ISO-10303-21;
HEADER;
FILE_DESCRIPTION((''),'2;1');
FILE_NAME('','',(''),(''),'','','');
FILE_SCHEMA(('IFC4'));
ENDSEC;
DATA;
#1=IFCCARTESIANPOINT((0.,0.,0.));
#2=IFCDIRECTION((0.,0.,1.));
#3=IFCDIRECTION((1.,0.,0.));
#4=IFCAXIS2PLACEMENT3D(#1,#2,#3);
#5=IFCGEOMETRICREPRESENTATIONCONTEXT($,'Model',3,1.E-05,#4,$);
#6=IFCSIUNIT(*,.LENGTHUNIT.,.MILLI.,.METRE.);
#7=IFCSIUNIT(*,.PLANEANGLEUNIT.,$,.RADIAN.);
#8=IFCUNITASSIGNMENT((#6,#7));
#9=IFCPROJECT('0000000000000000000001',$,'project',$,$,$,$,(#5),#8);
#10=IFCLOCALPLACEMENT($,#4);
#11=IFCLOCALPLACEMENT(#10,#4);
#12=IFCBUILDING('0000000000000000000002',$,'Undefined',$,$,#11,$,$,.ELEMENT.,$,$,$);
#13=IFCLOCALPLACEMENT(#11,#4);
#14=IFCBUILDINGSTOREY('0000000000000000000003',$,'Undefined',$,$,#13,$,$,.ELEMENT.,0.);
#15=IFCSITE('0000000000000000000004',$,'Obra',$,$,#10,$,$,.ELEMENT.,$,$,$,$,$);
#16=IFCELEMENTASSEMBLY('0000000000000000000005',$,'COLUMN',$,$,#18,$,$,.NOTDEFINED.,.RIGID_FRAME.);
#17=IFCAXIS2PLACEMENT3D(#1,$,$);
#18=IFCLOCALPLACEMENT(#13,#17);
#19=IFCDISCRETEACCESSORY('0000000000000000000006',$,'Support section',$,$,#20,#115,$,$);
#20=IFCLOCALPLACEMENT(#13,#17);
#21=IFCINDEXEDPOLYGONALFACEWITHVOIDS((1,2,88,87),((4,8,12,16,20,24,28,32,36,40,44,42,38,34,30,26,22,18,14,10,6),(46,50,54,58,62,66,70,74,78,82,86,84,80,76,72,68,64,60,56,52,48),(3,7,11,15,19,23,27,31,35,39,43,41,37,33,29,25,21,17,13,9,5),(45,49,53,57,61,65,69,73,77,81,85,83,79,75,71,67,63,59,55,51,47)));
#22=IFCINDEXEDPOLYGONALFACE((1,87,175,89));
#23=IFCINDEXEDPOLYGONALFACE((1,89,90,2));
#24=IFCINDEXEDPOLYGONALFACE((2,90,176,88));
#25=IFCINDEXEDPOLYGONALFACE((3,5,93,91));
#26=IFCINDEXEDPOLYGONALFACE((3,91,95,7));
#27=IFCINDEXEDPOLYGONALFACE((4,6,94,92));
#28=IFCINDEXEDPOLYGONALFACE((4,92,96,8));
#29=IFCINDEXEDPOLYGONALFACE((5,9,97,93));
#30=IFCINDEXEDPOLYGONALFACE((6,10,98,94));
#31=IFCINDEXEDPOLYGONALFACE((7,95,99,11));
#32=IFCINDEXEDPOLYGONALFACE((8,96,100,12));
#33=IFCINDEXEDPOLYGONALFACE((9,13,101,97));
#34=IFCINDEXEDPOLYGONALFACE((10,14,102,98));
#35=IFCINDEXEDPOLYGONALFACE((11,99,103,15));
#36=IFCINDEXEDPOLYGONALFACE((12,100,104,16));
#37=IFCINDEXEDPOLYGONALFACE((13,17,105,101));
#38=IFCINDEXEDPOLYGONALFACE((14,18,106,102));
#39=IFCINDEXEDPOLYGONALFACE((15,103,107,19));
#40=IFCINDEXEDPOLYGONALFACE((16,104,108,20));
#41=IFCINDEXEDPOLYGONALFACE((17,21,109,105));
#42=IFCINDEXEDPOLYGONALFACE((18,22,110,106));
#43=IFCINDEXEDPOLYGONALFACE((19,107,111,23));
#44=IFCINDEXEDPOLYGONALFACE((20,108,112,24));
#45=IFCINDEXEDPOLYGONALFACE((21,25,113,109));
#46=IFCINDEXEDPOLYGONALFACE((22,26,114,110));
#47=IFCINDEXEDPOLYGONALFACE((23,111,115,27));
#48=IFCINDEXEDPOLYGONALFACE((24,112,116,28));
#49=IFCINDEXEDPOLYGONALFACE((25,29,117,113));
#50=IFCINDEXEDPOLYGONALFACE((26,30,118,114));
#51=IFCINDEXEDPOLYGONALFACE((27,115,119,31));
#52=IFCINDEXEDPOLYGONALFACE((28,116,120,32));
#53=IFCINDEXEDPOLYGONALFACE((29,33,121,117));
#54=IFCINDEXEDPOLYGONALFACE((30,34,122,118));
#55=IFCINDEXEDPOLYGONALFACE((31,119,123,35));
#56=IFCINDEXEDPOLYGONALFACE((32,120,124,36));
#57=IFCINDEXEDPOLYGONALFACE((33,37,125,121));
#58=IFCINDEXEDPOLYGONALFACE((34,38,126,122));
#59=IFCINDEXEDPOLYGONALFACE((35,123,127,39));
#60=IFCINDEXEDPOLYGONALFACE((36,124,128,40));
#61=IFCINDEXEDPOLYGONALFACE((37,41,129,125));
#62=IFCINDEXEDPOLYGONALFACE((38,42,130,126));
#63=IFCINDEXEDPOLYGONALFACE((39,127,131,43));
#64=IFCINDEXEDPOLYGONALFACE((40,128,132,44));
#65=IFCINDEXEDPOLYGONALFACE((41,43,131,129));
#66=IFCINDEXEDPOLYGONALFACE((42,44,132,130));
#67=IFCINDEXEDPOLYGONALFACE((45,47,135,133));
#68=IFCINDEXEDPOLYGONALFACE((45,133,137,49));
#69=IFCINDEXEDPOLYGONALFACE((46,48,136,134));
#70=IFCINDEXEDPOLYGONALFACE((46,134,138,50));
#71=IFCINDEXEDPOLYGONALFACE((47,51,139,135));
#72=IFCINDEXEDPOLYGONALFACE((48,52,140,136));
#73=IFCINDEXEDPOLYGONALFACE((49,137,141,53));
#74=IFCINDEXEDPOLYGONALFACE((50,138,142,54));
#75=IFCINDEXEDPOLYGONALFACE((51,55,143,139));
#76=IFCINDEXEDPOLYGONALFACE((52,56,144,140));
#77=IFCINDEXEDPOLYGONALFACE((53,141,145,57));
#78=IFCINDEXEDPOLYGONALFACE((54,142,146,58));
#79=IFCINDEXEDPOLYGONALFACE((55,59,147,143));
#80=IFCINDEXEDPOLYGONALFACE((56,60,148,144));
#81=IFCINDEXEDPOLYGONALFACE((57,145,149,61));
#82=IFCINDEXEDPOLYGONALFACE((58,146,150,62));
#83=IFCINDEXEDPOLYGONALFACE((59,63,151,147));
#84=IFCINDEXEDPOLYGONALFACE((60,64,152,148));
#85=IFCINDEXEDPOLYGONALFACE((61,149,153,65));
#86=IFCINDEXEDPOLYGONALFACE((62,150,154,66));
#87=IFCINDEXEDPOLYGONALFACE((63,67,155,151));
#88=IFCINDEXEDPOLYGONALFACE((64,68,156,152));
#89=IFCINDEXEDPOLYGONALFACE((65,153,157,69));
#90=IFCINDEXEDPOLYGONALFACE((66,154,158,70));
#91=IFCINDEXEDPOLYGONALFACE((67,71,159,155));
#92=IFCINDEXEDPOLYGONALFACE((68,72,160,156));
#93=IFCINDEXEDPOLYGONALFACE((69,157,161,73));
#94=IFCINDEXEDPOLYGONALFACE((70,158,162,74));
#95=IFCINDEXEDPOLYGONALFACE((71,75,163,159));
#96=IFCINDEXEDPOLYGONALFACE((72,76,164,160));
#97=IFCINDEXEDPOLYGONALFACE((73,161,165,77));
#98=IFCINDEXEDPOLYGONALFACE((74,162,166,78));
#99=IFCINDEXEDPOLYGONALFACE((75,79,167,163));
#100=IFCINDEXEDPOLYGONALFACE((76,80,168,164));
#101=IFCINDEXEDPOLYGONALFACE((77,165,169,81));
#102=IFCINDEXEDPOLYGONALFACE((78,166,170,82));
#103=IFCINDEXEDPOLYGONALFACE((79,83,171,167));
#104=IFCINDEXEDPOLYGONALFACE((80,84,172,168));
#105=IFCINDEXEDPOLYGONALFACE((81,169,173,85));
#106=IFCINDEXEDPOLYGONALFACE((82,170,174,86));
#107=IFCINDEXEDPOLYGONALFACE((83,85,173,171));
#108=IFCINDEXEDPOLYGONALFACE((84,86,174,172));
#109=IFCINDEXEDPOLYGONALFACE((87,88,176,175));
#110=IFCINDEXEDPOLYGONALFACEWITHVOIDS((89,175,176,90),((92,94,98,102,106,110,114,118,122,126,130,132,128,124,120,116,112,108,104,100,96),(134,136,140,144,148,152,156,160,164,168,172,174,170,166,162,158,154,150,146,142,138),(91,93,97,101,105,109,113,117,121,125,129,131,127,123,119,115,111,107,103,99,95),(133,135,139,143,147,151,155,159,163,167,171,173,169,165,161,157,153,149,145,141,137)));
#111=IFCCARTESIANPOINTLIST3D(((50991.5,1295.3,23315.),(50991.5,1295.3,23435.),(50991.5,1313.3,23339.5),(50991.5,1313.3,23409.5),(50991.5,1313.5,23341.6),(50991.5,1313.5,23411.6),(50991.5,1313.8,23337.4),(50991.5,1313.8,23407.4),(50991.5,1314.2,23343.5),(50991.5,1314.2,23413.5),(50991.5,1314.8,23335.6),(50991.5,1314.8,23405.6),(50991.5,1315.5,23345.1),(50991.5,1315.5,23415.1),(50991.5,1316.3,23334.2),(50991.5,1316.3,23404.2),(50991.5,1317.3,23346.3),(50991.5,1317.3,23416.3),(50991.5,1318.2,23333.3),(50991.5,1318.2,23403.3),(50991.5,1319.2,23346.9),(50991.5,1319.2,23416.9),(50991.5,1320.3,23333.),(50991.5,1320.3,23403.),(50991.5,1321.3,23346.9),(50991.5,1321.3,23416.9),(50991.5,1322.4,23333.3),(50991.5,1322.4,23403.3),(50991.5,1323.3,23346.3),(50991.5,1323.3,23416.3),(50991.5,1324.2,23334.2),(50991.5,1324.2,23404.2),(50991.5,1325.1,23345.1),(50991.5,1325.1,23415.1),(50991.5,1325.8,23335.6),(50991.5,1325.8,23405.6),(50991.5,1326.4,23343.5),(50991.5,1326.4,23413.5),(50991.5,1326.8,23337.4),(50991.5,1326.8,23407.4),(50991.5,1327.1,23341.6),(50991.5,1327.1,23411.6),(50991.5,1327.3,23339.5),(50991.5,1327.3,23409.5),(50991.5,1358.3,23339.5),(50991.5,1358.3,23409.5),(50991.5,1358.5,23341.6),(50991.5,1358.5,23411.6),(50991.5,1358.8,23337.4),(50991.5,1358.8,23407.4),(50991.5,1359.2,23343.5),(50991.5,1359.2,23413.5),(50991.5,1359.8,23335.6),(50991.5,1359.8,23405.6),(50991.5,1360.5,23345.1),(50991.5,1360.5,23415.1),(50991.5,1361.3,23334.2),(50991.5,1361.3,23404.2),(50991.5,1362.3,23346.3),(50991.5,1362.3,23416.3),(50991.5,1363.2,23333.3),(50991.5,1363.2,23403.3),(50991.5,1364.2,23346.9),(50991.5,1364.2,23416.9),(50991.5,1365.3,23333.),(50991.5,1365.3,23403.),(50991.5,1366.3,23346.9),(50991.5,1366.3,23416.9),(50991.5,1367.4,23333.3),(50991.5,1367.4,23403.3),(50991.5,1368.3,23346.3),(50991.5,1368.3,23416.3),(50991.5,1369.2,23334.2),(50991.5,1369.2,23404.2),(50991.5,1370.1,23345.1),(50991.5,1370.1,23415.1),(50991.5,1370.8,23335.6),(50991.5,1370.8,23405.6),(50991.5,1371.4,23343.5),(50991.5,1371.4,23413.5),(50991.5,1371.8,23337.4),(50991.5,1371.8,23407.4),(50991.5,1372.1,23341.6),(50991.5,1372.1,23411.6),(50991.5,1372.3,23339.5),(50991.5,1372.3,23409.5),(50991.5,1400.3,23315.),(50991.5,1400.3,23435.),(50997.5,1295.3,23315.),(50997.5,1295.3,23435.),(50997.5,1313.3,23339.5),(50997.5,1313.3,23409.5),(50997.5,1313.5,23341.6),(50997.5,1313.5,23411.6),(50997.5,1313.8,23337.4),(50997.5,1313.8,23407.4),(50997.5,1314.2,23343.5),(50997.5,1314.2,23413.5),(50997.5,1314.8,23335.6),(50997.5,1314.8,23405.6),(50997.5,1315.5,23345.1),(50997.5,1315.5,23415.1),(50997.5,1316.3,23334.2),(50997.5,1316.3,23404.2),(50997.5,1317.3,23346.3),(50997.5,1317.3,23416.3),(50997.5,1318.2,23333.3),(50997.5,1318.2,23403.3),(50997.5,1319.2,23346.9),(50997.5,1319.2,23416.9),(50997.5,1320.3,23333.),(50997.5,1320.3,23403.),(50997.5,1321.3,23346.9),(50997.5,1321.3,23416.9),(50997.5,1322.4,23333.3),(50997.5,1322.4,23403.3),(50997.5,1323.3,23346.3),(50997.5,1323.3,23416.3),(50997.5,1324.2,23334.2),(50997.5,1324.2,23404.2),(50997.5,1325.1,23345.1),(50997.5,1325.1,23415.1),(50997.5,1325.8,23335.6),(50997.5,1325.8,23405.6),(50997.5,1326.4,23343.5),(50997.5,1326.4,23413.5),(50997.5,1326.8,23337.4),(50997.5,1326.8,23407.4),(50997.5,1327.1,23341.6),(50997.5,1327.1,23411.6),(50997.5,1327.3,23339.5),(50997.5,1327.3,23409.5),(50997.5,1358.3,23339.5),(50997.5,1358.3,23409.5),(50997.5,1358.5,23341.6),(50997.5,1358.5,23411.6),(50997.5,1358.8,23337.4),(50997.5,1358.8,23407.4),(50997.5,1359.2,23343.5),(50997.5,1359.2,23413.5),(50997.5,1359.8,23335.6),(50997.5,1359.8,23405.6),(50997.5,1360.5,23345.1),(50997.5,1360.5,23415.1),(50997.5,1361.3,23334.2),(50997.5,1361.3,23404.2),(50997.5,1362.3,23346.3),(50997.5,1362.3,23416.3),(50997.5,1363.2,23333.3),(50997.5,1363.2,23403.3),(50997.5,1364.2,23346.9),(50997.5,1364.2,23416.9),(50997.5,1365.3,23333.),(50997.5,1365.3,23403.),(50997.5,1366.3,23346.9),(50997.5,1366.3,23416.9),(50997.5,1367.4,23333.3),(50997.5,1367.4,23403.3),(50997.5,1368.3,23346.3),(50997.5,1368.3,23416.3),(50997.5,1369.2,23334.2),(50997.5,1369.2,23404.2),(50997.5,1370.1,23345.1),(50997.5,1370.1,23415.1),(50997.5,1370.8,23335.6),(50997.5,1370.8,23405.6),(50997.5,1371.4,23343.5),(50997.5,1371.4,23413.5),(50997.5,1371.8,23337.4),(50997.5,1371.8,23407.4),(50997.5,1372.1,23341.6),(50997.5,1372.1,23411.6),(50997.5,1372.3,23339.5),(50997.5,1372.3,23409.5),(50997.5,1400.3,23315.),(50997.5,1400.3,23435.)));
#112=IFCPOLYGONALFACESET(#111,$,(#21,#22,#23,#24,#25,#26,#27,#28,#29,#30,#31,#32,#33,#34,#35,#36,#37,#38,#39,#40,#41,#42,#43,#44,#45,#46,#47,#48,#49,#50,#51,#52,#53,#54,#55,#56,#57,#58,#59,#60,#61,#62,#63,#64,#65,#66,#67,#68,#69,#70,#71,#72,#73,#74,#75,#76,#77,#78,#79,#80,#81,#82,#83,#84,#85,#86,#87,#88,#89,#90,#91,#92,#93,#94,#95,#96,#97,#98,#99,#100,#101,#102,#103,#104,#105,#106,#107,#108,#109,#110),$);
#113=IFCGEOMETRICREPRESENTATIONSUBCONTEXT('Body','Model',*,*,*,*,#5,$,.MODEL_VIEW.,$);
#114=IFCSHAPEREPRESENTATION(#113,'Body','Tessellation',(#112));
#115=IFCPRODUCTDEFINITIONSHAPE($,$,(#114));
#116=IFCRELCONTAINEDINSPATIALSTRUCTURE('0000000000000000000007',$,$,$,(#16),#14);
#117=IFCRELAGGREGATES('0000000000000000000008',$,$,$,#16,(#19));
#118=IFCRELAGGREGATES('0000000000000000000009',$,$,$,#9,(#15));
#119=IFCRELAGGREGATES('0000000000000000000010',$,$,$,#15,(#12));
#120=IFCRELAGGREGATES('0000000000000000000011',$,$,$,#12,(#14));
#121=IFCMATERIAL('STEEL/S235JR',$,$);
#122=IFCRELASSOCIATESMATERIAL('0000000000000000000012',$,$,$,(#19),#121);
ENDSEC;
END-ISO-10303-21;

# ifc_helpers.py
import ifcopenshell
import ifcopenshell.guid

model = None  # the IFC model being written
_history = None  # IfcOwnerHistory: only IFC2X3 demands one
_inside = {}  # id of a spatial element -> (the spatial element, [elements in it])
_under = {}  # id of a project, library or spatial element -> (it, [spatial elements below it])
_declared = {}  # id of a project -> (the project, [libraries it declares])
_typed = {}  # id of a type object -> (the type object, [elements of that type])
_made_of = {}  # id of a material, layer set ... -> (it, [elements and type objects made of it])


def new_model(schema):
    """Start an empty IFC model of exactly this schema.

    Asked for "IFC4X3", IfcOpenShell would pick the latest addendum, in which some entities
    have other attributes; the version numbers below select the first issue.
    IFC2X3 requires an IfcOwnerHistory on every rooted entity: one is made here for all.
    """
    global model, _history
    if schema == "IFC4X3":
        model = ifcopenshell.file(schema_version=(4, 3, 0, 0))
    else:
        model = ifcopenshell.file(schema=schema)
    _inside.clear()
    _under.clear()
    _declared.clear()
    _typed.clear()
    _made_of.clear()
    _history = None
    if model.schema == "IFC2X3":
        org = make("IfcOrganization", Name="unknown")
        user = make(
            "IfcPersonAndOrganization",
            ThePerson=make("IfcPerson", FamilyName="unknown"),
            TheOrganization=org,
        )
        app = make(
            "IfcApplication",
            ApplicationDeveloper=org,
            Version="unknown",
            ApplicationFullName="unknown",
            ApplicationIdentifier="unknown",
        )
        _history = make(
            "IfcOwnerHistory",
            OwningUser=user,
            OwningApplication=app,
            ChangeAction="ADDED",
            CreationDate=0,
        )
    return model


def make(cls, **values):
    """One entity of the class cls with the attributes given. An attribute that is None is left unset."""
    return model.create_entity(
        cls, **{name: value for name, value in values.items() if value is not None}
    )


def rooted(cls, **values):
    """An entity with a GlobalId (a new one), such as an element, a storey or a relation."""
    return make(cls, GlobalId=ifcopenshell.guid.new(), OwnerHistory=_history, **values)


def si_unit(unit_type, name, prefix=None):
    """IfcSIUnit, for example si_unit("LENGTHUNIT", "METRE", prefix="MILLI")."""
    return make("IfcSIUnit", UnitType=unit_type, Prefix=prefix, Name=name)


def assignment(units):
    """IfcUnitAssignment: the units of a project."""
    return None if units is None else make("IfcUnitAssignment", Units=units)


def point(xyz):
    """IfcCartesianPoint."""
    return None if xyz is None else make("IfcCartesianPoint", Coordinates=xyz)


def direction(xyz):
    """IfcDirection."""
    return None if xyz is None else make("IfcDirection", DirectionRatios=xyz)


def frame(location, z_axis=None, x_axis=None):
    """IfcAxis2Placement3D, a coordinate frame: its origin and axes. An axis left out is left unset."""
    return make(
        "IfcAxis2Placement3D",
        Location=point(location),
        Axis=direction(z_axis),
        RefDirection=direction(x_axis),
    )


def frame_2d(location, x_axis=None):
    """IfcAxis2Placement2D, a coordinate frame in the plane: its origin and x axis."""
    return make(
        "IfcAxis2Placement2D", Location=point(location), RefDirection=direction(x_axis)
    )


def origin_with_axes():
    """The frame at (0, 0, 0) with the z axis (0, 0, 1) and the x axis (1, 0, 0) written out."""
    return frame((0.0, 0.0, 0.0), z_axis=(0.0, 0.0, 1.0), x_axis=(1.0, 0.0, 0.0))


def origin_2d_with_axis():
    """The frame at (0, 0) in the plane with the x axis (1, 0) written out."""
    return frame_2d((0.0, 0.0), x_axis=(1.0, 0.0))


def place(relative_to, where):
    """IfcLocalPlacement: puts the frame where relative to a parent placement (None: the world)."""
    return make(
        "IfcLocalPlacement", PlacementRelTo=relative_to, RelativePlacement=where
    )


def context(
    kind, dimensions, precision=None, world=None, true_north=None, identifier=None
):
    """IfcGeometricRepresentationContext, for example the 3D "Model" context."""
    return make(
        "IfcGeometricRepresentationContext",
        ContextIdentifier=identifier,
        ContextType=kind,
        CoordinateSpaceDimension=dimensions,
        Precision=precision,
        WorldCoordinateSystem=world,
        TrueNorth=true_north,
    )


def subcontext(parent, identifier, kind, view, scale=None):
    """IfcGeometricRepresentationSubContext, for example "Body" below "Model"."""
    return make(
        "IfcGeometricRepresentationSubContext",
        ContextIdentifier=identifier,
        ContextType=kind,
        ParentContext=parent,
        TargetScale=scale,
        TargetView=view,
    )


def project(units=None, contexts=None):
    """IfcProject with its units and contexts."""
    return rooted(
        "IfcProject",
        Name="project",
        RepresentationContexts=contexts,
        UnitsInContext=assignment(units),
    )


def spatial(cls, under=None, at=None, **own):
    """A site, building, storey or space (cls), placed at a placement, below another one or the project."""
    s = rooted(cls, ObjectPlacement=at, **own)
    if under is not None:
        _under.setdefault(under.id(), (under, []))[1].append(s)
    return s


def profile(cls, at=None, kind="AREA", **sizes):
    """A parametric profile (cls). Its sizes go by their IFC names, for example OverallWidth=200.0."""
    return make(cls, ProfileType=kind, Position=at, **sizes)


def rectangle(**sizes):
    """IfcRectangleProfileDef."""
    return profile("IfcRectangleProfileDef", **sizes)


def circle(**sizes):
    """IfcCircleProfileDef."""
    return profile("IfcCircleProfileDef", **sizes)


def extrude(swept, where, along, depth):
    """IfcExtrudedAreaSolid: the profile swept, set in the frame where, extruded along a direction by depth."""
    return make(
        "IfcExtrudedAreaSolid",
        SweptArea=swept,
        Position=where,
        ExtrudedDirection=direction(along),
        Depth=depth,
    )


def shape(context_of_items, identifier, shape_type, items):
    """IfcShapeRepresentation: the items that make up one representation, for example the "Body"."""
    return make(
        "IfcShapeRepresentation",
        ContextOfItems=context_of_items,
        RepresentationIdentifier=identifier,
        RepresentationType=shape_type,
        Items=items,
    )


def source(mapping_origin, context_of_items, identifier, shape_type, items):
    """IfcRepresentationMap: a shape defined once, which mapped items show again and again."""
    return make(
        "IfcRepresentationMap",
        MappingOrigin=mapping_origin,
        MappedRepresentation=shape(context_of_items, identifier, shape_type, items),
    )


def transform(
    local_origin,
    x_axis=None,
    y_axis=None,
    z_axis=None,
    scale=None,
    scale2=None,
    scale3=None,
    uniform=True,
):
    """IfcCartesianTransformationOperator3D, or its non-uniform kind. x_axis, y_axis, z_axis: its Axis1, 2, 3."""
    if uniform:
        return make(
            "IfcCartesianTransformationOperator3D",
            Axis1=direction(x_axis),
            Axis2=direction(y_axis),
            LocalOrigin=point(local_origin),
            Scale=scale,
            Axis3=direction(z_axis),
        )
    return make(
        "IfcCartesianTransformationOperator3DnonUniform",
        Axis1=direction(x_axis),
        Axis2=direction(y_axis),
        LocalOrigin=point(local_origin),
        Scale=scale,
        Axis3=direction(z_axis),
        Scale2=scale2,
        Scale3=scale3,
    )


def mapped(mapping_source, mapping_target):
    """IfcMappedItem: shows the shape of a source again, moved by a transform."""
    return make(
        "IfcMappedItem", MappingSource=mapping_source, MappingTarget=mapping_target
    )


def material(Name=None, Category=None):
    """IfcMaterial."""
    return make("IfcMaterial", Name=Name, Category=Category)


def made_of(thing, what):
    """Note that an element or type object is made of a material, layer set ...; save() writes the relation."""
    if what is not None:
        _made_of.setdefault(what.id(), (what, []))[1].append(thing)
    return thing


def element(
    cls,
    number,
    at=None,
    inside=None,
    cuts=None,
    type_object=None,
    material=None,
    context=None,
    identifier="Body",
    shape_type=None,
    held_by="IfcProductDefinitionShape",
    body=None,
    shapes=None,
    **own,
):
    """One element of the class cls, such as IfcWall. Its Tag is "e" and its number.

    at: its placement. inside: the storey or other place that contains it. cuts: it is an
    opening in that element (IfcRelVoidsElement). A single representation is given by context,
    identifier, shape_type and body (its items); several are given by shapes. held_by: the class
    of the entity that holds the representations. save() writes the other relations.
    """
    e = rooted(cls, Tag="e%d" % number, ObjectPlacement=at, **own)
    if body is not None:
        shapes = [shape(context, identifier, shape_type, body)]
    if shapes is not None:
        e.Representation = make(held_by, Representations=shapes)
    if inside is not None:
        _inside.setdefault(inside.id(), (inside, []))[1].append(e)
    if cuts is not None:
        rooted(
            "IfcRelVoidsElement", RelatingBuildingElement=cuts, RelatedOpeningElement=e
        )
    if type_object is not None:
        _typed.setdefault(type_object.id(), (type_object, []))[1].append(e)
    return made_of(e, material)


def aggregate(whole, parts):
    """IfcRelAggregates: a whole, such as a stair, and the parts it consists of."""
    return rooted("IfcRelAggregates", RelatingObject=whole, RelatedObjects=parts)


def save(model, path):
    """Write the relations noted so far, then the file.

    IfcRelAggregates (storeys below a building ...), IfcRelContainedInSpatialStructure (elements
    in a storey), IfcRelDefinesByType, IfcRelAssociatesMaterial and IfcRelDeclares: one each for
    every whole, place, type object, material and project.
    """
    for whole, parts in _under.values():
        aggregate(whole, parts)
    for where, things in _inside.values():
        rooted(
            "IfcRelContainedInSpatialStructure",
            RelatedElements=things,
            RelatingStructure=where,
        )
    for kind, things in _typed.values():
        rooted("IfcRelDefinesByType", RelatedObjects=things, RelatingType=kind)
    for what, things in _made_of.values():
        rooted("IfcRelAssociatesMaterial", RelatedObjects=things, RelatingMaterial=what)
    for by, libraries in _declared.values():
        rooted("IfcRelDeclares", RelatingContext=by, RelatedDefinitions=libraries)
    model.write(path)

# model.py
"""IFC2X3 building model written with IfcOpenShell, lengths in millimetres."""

from ifc_helpers import new_model, si_unit, frame, origin_with_axes, origin_2d_with_axis, place, context, subcontext, project, spatial, rectangle, circle, extrude, source, transform, mapped, material, element, aggregate, save


model = new_model("IFC2X3")

# Units and contexts
model_context = context("Model", 3, precision=1e-05, world=origin_with_axes())
body_context = subcontext(model_context, "Body", "Model", "MODEL_VIEW")
ifc_project = project(units=[si_unit("LENGTHUNIT", "METRE", prefix="MILLI"), si_unit("PLANEANGLEUNIT", "RADIAN")], contexts=[model_context])

# Site, building, storey
site_placement = place(None, origin_with_axes())
site = spatial("IfcSite", under=ifc_project, at=site_placement, Name="Obra", CompositionType="ELEMENT")
building_placement = place(site_placement, origin_with_axes())
building = spatial("IfcBuilding", under=site, at=building_placement, Name="Undefined", CompositionType="ELEMENT")
storey_placement = place(building_placement, origin_with_axes())
storey = spatial("IfcBuildingStorey", under=building, at=storey_placement, Name="Undefined", CompositionType="ELEMENT", Elevation=0.0)

# Shared definitions
ifc_material_1 = material(Name="STEEL/S235JR")

# Element assembly, discrete accessory, opening
assembly_1_placement = place(storey_placement, origin_with_axes())
assembly_1 = element("IfcElementAssembly", 1, at=assembly_1_placement, inside=storey, Name="COLUMN", AssemblyPlace="NOTDEFINED", PredefinedType="RIGID_FRAME")
discrete_accessory_1_placement = place(assembly_1_placement, frame((50994.5, 1347.8, 23315.0), z_axis=(0.0, 0.0, 1.0), x_axis=(0.0, 1.0, 0.0)))
discrete_accessory_1 = element("IfcDiscreteAccessory", 2, at=discrete_accessory_1_placement, material=ifc_material_1, Name="Support section", context=body_context, shape_type="SweptSolid", body=[
    extrude(rectangle(XDim=6.0, YDim=105.0, at=origin_2d_with_axis()), frame((0.0, 0.0, 120.0), z_axis=(0.0, 0.0, -1.0), x_axis=(0.0, 1.0, 0.0)), (0.0, 0.0, 1.0), 120.0),
])
shared_shape_1 = source(origin_with_axes(), body_context, "Body", "SweptSolid", [
    extrude(circle(Radius=7.0, at=origin_2d_with_axis()), frame((0.0, -8.6, 0.0), z_axis=(0.0, 1.0, 0.0), x_axis=(1.0, 0.0, 0.0)), (0.0, 0.0, 1.0), 6.2),
])
opening_1_placement = place(assembly_1_placement, frame((51000.0, 1390.3, 23455.0), z_axis=(0.0, -1.0, 0.0), x_axis=(0.0, 0.0, -1.0)))
element("IfcOpeningElement", 3, at=opening_1_placement, cuts=discrete_accessory_1, ObjectType="Opening", context=body_context, shape_type="MappedRepresentation", body=[
    mapped(shared_shape_1, transform((45.0, 0.0, 25.0))),
    mapped(shared_shape_1, transform((45.0, 0.0, 70.0))),
    mapped(shared_shape_1, transform((115.0, 0.0, 25.0))),
    mapped(shared_shape_1, transform((115.0, 0.0, 70.0))),
])

aggregate(assembly_1, [discrete_accessory_1])

save(model, "model.ifc")
